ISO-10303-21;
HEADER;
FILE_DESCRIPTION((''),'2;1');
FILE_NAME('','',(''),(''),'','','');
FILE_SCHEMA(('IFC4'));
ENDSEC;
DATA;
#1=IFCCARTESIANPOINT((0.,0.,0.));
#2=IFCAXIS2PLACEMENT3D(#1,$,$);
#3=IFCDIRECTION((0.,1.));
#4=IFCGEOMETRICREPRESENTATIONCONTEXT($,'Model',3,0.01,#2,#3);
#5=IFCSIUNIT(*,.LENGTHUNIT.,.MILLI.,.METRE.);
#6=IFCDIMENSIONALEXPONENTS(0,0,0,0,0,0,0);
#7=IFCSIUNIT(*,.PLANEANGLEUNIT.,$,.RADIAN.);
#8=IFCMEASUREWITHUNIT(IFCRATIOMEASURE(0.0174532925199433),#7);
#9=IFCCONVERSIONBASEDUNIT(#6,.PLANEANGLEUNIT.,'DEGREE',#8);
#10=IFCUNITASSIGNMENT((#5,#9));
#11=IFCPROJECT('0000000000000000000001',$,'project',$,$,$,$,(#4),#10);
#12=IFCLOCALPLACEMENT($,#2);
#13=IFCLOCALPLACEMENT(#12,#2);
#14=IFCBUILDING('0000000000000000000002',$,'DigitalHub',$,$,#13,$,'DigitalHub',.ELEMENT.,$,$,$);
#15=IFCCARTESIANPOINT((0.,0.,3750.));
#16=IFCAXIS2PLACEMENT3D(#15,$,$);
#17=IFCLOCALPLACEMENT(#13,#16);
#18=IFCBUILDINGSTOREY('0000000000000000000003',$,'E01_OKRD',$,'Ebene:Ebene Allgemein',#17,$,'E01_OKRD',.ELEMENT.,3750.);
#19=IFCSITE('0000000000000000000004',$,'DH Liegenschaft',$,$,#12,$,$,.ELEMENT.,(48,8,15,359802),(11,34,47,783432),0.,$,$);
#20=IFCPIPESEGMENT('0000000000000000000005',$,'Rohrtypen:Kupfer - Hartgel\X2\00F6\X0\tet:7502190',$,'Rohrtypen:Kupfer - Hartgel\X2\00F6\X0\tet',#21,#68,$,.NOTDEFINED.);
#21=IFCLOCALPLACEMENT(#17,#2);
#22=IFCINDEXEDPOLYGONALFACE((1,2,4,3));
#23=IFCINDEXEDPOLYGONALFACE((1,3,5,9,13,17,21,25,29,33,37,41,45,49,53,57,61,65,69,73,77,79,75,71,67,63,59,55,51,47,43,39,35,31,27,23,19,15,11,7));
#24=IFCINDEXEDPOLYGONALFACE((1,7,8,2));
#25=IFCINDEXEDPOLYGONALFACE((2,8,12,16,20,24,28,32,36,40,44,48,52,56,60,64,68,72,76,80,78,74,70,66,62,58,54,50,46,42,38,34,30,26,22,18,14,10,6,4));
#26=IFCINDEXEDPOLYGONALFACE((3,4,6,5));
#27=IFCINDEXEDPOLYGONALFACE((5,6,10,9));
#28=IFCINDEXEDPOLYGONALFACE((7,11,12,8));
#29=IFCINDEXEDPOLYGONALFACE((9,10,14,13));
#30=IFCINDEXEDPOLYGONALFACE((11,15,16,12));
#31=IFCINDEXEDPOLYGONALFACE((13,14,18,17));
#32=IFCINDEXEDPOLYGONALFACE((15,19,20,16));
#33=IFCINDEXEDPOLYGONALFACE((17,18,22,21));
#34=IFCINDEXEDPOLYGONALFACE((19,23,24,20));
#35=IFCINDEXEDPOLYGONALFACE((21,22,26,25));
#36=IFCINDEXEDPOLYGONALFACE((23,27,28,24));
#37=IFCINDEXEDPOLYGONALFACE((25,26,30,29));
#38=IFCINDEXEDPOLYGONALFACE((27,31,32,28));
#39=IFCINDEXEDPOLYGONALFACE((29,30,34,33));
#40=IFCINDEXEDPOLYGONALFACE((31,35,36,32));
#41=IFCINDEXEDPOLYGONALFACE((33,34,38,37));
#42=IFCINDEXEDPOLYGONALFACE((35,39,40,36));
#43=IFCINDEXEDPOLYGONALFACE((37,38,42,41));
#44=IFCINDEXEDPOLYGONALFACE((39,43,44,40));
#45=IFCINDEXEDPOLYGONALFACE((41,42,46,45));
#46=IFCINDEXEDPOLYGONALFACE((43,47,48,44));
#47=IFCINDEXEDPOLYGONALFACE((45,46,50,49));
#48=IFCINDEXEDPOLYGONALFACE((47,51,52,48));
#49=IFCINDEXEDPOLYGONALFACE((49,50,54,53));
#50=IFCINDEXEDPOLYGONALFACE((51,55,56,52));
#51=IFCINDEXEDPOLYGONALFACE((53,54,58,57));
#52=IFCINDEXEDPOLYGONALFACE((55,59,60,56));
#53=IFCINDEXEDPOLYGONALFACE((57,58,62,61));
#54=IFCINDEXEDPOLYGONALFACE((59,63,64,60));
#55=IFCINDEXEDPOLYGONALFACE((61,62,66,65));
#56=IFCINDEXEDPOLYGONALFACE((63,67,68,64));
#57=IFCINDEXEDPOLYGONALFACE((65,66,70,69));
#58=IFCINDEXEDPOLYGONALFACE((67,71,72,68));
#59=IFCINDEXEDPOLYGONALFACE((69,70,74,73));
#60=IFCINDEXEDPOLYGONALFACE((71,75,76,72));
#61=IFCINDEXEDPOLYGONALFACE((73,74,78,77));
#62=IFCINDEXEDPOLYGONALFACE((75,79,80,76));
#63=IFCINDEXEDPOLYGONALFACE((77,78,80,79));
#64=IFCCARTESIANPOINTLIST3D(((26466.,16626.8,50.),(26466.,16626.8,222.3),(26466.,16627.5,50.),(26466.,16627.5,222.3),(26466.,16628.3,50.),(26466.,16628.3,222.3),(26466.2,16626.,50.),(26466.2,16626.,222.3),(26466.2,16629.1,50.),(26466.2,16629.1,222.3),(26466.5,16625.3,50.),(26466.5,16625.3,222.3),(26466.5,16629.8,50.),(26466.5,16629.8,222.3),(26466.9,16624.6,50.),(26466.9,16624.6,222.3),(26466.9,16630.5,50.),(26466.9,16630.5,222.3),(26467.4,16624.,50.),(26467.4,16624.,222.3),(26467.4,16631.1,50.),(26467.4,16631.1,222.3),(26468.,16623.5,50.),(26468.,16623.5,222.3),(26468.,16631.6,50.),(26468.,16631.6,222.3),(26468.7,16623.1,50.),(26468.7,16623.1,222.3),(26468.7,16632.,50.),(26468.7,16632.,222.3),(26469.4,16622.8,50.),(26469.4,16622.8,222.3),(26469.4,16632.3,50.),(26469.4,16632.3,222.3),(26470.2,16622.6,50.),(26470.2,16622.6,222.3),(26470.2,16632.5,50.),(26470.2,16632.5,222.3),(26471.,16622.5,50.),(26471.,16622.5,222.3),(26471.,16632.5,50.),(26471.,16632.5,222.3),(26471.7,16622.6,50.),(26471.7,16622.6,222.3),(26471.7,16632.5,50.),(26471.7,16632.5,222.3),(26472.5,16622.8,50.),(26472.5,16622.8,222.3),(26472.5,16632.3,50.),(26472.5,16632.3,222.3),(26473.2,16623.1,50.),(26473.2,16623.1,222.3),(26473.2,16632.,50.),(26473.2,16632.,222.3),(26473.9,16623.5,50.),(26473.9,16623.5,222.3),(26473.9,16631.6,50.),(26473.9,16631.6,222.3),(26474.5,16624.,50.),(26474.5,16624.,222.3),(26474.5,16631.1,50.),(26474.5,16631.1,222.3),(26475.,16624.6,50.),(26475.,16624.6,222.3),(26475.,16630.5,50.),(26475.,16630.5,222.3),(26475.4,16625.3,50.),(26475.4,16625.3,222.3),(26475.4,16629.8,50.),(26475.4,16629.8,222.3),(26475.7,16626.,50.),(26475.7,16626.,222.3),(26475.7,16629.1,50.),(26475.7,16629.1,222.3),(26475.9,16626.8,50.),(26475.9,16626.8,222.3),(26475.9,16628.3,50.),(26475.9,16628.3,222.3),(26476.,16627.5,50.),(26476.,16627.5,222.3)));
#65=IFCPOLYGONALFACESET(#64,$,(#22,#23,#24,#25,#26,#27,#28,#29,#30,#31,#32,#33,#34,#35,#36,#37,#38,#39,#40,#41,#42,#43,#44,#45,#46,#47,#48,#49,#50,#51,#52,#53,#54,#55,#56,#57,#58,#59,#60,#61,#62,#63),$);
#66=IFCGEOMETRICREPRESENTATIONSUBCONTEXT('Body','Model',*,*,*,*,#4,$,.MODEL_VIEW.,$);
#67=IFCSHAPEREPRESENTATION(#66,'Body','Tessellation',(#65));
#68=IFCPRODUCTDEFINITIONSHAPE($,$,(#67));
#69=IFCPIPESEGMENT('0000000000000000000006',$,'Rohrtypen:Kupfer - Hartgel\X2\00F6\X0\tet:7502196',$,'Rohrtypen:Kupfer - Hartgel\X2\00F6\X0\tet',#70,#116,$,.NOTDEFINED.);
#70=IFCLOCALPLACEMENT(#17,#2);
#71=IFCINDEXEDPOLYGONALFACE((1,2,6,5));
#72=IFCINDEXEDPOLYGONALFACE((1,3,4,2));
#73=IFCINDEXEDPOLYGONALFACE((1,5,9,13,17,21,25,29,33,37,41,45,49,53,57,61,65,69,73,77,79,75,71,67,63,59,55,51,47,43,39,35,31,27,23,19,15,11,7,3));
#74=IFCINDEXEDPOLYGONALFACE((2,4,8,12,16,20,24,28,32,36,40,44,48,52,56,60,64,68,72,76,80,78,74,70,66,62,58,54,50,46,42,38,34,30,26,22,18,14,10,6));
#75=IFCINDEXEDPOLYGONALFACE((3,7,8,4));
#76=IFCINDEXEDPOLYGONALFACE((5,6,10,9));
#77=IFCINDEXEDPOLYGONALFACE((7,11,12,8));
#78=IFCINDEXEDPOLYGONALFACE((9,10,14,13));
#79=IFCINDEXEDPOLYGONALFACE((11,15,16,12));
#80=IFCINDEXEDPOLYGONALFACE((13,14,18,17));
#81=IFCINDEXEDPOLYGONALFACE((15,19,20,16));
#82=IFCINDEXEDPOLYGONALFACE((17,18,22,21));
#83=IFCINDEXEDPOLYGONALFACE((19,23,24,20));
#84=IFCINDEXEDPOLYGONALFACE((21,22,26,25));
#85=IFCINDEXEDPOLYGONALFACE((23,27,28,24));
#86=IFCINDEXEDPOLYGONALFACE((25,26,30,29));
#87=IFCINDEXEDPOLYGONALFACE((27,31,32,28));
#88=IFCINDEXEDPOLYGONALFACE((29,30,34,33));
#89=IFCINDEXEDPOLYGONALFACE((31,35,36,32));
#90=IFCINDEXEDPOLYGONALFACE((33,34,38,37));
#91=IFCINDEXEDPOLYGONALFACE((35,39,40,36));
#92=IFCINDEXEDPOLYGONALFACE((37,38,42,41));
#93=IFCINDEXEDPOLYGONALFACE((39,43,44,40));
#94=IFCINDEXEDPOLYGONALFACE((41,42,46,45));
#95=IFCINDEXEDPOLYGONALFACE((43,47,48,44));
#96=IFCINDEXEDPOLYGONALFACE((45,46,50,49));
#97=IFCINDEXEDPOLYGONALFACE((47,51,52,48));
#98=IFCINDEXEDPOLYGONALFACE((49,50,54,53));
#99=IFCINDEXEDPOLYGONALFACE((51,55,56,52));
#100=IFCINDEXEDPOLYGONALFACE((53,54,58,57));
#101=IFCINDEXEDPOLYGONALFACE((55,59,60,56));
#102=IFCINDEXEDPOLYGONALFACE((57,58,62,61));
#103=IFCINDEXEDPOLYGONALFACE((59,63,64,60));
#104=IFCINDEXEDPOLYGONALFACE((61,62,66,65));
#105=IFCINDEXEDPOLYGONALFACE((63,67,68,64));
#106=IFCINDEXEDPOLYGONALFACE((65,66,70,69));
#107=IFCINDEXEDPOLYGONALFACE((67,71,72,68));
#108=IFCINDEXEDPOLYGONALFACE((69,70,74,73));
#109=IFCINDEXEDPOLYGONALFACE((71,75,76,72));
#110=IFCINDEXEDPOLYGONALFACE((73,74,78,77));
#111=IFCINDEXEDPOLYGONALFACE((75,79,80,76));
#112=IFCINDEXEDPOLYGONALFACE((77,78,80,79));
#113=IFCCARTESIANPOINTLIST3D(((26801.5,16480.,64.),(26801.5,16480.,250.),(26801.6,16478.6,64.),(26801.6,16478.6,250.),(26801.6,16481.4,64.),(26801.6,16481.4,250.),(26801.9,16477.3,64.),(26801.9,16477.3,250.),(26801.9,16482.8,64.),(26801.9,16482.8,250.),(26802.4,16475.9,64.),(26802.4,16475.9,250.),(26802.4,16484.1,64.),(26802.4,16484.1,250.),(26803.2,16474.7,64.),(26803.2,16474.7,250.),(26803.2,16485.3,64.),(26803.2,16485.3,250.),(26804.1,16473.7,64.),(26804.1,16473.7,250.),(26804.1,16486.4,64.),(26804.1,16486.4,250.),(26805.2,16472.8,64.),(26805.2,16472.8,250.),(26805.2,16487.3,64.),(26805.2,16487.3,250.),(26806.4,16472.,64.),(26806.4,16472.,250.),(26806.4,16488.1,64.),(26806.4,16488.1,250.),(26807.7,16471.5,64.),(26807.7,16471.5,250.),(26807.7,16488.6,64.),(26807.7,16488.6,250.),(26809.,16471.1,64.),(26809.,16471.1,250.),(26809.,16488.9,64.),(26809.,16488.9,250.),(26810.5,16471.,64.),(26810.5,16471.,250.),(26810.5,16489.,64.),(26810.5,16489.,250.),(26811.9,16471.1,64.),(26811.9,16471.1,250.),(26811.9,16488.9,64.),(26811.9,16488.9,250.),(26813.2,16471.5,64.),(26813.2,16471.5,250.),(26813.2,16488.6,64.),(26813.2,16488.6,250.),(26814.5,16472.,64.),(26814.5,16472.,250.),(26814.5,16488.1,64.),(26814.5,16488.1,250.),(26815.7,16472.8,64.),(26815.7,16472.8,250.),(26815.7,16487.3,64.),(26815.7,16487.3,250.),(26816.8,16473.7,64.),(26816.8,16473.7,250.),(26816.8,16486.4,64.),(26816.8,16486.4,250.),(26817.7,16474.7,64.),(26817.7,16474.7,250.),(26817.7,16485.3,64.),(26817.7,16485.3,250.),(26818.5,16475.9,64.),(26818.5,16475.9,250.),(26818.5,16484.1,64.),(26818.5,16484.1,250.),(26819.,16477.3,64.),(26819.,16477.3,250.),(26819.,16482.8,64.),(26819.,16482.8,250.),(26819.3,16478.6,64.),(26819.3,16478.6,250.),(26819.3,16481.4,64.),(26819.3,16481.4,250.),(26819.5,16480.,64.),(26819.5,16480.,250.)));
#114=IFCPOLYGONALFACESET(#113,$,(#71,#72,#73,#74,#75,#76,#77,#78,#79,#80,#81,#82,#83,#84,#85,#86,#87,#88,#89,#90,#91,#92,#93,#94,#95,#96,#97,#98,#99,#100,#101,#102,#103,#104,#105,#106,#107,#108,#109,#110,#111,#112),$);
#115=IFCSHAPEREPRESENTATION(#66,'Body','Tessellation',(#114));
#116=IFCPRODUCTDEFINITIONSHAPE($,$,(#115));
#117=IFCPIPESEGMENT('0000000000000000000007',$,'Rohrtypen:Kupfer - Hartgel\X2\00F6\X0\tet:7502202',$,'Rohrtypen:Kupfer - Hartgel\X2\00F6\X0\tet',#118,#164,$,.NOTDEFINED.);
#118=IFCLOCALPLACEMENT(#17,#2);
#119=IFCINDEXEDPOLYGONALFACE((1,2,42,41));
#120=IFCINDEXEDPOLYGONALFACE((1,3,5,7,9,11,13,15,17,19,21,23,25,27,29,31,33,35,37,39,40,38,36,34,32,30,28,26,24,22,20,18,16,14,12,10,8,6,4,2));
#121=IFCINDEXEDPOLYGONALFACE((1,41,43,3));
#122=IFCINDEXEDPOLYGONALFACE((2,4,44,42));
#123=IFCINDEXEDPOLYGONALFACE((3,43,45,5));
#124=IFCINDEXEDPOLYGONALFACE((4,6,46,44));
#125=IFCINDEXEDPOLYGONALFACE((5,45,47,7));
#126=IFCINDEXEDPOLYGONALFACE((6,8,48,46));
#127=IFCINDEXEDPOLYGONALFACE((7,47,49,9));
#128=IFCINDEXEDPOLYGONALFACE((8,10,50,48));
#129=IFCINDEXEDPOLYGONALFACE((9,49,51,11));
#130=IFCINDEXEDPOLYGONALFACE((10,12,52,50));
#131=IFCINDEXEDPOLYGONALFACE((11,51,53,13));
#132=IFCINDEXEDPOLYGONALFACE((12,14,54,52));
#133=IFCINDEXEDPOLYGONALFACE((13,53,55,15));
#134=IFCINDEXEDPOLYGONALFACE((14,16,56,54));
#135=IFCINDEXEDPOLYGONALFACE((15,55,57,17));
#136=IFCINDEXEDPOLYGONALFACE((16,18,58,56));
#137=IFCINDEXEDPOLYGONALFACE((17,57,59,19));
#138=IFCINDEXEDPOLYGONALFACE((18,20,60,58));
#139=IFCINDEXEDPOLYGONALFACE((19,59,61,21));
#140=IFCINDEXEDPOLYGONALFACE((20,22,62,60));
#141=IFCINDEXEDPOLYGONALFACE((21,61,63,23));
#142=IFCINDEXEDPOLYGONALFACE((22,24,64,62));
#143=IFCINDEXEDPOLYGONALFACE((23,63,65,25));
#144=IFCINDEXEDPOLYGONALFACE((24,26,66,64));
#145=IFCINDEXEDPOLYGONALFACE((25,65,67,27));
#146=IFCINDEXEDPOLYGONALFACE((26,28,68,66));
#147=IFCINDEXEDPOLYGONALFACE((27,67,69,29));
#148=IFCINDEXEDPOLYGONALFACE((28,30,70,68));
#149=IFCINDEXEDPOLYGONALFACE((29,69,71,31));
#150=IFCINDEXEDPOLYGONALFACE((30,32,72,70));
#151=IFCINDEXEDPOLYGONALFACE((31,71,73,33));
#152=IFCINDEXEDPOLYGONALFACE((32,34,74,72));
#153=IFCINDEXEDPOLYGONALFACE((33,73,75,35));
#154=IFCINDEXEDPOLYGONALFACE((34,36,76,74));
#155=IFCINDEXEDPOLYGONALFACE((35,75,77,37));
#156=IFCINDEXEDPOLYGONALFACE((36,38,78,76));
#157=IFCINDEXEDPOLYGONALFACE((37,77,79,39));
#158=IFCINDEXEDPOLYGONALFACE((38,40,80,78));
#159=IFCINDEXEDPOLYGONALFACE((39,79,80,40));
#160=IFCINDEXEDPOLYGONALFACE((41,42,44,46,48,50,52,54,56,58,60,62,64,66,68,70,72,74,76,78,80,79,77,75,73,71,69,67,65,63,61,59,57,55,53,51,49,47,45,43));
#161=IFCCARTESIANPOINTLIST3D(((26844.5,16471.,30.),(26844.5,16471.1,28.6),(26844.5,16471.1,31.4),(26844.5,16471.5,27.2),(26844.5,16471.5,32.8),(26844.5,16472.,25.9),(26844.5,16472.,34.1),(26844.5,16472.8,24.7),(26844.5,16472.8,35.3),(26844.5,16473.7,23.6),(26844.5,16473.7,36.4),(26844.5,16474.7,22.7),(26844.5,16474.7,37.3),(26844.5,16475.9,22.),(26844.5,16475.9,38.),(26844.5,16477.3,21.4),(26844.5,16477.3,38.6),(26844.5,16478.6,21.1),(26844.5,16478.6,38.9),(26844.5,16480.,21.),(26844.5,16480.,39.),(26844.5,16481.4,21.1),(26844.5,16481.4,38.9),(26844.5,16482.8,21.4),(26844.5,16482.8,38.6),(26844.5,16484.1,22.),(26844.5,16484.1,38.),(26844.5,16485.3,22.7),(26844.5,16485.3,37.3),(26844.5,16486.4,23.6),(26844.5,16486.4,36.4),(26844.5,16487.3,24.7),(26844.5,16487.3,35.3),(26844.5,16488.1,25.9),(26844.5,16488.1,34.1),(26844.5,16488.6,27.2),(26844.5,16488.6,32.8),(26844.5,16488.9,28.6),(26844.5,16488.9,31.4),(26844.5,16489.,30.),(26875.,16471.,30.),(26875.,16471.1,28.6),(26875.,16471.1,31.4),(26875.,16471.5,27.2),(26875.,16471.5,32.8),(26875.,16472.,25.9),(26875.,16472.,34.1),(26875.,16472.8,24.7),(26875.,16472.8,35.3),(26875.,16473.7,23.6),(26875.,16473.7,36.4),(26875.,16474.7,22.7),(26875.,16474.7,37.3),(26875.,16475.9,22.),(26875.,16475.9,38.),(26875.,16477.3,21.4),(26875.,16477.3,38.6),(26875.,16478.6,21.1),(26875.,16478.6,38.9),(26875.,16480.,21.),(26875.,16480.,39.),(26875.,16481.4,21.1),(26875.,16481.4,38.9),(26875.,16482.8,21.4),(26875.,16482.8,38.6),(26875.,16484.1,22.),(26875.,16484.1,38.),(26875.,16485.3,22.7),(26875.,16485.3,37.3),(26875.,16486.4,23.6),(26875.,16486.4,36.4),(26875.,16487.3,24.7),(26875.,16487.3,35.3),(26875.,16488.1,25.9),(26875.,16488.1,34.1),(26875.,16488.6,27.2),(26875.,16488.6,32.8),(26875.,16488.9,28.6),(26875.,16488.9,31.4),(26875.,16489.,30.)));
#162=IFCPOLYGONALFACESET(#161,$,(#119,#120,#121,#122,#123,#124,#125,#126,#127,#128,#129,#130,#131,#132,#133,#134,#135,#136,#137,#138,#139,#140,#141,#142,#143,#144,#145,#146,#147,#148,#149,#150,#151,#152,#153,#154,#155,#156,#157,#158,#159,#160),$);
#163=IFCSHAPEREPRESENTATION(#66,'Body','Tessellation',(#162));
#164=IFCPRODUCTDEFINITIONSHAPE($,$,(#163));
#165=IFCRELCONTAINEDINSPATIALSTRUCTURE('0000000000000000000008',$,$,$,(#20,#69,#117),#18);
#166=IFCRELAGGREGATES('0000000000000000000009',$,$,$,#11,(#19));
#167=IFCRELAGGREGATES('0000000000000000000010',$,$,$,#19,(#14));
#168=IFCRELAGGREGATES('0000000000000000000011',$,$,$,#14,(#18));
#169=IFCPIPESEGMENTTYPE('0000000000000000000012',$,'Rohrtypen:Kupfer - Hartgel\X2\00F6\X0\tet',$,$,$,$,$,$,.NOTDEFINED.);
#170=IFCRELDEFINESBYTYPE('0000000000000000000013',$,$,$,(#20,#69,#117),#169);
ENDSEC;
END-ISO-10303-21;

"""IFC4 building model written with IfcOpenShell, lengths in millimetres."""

from ifc_helpers import new_model, entity, si_unit, converted_unit, direction, frame, origin, place, context, subcontext, project, spatial, indexed_curve, outline, extrude, type_object, element, save


model = new_model("IFC4")

# Units and contexts
model_context = context("Model", 3, precision=0.01, world=origin(), true_north=direction((0.0, 1.0)))
body_context = subcontext(model_context, "Body", "Model", "MODEL_VIEW")
ifc_project = project(units=[si_unit("LENGTHUNIT", "METRE", prefix="MILLI"), converted_unit("PLANEANGLEUNIT", "DEGREE", entity("IfcRatioMeasure", 0.0174532925199433), si_unit("PLANEANGLEUNIT", "RADIAN"), dimensions=[0, 0, 0, 0, 0, 0, 0])], contexts=[model_context])

# Site, building, storey
site_placement = place(None, origin())
site = spatial("IfcSite", under=ifc_project, at=site_placement, Name="DH Liegenschaft", CompositionType="ELEMENT", RefLatitude=(48, 8, 15, 359802), RefLongitude=(11, 34, 47, 783432), RefElevation=0.0)
building_placement = place(site_placement, origin())
building = spatial("IfcBuilding", under=site, at=building_placement, Name="DigitalHub", LongName="DigitalHub", CompositionType="ELEMENT")
storey_placement = place(building_placement, frame((0.0, 0.0, 3750.0)))
storey = spatial("IfcBuildingStorey", under=building, at=storey_placement, Name="E01_OKRD", ObjectType="Ebene:Ebene Allgemein", LongName="E01_OKRD", CompositionType="ELEMENT", Elevation=3750.0)

# Pipe segments
pipe_segment_type = type_object("IfcPipeSegmentType", Name="Rohrtypen:Kupfer - Hartgelötet", PredefinedType="NOTDEFINED")
pipe_segment_1_placement = place(storey_placement, frame((26464.4, 16620.9, 50.0)))
element("IfcPipeSegment", 1, at=pipe_segment_1_placement, inside=storey, type_object=pipe_segment_type, Name="Rohrtypen:Kupfer - Hartgelötet:7502190", ObjectType="Rohrtypen:Kupfer - Hartgelötet", PredefinedType="NOTDEFINED", context=body_context, shape_type="SweptSolid", body=[
    extrude(outline(indexed_curve([(5.0, 0.0), (4.9, 0.8), (4.8, 1.5), (4.5, 2.3), (4.0, 2.9), (3.5, 3.5), (2.9, 4.0), (2.3, 4.5), (1.5, 4.8), (0.8, 4.9), (0.0, 5.0), (-0.8, 4.9), (-1.5, 4.8), (-2.3, 4.5), (-2.9, 4.0), (-3.5, 3.5), (-4.0, 2.9), (-4.5, 2.3), (-4.8, 1.5), (-4.9, 0.8), (-5.0, 0.0), (-4.9, -0.8), (-4.8, -1.5), (-4.5, -2.3), (-4.0, -2.9), (-3.5, -3.5), (-2.9, -4.0), (-2.3, -4.5), (-1.5, -4.8), (-0.8, -4.9), (0.0, -5.0), (0.8, -4.9), (1.5, -4.8), (2.3, -4.5), (2.9, -4.0), (3.5, -3.5), (4.0, -2.9), (4.5, -2.3), (4.8, -1.5), (4.9, -0.8), (5.0, 0.0)], self_intersect=False)), frame((6.6, 6.6, 0.0)), (0.0, 0.0, 1.0), 172.3),
])
pipe_segment_2_placement = place(storey_placement, frame((26799.9, 16469.4, 64.0)))
element("IfcPipeSegment", 2, at=pipe_segment_2_placement, inside=storey, type_object=pipe_segment_type, Name="Rohrtypen:Kupfer - Hartgelötet:7502196", ObjectType="Rohrtypen:Kupfer - Hartgelötet", PredefinedType="NOTDEFINED", context=body_context, shape_type="SweptSolid", body=[
    extrude(outline(indexed_curve([(9.0, 0.0), (8.9, 1.4), (8.6, 2.8), (8.0, 4.1), (7.3, 5.3), (6.4, 6.4), (5.3, 7.3), (4.1, 8.0), (2.8, 8.6), (1.4, 8.9), (0.0, 9.0), (-1.4, 8.9), (-2.8, 8.6), (-4.1, 8.0), (-5.3, 7.3), (-6.4, 6.4), (-7.3, 5.3), (-8.0, 4.1), (-8.6, 2.8), (-8.9, 1.4), (-9.0, 0.0), (-8.9, -1.4), (-8.6, -2.8), (-8.0, -4.1), (-7.3, -5.3), (-6.4, -6.4), (-5.3, -7.3), (-4.1, -8.0), (-2.8, -8.6), (-1.4, -8.9), (0.0, -9.0), (1.4, -8.9), (2.8, -8.6), (4.1, -8.0), (5.3, -7.3), (6.4, -6.4), (7.3, -5.3), (8.0, -4.1), (8.6, -2.8), (8.9, -1.4), (9.0, 0.0)], self_intersect=False)), frame((10.6, 10.6, 0.0)), (0.0, 0.0, 1.0), 186.0),
])
pipe_segment_3_placement = place(storey_placement, frame((26844.5, 16469.4, 19.4)))
element("IfcPipeSegment", 3, at=pipe_segment_3_placement, inside=storey, type_object=pipe_segment_type, Name="Rohrtypen:Kupfer - Hartgelötet:7502202", ObjectType="Rohrtypen:Kupfer - Hartgelötet", PredefinedType="NOTDEFINED", context=body_context, shape_type="SweptSolid", body=[
    extrude(outline(indexed_curve([(9.0, 0.0), (8.9, 1.4), (8.6, 2.8), (8.0, 4.1), (7.3, 5.3), (6.4, 6.4), (5.3, 7.3), (4.1, 8.0), (2.8, 8.6), (1.4, 8.9), (0.0, 9.0), (-1.4, 8.9), (-2.8, 8.6), (-4.1, 8.0), (-5.3, 7.3), (-6.4, 6.4), (-7.3, 5.3), (-8.0, 4.1), (-8.6, 2.8), (-8.9, 1.4), (-9.0, 0.0), (-8.9, -1.4), (-8.6, -2.8), (-8.0, -4.1), (-7.3, -5.3), (-6.4, -6.4), (-5.3, -7.3), (-4.1, -8.0), (-2.8, -8.6), (-1.4, -8.9), (0.0, -9.0), (1.4, -8.9), (2.8, -8.6), (4.1, -8.0), (5.3, -7.3), (6.4, -6.4), (7.3, -5.3), (8.0, -4.1), (8.6, -2.8), (8.9, -1.4), (9.0, 0.0)], self_intersect=False)), frame((0.0, 10.6, 10.6), z_axis=(1.0, 0.0, 0.0), x_axis=(0.0, -1.0, 0.0)), (0.0, 0.0, 1.0), 30.5),
])

save(model, "model.ifc")
